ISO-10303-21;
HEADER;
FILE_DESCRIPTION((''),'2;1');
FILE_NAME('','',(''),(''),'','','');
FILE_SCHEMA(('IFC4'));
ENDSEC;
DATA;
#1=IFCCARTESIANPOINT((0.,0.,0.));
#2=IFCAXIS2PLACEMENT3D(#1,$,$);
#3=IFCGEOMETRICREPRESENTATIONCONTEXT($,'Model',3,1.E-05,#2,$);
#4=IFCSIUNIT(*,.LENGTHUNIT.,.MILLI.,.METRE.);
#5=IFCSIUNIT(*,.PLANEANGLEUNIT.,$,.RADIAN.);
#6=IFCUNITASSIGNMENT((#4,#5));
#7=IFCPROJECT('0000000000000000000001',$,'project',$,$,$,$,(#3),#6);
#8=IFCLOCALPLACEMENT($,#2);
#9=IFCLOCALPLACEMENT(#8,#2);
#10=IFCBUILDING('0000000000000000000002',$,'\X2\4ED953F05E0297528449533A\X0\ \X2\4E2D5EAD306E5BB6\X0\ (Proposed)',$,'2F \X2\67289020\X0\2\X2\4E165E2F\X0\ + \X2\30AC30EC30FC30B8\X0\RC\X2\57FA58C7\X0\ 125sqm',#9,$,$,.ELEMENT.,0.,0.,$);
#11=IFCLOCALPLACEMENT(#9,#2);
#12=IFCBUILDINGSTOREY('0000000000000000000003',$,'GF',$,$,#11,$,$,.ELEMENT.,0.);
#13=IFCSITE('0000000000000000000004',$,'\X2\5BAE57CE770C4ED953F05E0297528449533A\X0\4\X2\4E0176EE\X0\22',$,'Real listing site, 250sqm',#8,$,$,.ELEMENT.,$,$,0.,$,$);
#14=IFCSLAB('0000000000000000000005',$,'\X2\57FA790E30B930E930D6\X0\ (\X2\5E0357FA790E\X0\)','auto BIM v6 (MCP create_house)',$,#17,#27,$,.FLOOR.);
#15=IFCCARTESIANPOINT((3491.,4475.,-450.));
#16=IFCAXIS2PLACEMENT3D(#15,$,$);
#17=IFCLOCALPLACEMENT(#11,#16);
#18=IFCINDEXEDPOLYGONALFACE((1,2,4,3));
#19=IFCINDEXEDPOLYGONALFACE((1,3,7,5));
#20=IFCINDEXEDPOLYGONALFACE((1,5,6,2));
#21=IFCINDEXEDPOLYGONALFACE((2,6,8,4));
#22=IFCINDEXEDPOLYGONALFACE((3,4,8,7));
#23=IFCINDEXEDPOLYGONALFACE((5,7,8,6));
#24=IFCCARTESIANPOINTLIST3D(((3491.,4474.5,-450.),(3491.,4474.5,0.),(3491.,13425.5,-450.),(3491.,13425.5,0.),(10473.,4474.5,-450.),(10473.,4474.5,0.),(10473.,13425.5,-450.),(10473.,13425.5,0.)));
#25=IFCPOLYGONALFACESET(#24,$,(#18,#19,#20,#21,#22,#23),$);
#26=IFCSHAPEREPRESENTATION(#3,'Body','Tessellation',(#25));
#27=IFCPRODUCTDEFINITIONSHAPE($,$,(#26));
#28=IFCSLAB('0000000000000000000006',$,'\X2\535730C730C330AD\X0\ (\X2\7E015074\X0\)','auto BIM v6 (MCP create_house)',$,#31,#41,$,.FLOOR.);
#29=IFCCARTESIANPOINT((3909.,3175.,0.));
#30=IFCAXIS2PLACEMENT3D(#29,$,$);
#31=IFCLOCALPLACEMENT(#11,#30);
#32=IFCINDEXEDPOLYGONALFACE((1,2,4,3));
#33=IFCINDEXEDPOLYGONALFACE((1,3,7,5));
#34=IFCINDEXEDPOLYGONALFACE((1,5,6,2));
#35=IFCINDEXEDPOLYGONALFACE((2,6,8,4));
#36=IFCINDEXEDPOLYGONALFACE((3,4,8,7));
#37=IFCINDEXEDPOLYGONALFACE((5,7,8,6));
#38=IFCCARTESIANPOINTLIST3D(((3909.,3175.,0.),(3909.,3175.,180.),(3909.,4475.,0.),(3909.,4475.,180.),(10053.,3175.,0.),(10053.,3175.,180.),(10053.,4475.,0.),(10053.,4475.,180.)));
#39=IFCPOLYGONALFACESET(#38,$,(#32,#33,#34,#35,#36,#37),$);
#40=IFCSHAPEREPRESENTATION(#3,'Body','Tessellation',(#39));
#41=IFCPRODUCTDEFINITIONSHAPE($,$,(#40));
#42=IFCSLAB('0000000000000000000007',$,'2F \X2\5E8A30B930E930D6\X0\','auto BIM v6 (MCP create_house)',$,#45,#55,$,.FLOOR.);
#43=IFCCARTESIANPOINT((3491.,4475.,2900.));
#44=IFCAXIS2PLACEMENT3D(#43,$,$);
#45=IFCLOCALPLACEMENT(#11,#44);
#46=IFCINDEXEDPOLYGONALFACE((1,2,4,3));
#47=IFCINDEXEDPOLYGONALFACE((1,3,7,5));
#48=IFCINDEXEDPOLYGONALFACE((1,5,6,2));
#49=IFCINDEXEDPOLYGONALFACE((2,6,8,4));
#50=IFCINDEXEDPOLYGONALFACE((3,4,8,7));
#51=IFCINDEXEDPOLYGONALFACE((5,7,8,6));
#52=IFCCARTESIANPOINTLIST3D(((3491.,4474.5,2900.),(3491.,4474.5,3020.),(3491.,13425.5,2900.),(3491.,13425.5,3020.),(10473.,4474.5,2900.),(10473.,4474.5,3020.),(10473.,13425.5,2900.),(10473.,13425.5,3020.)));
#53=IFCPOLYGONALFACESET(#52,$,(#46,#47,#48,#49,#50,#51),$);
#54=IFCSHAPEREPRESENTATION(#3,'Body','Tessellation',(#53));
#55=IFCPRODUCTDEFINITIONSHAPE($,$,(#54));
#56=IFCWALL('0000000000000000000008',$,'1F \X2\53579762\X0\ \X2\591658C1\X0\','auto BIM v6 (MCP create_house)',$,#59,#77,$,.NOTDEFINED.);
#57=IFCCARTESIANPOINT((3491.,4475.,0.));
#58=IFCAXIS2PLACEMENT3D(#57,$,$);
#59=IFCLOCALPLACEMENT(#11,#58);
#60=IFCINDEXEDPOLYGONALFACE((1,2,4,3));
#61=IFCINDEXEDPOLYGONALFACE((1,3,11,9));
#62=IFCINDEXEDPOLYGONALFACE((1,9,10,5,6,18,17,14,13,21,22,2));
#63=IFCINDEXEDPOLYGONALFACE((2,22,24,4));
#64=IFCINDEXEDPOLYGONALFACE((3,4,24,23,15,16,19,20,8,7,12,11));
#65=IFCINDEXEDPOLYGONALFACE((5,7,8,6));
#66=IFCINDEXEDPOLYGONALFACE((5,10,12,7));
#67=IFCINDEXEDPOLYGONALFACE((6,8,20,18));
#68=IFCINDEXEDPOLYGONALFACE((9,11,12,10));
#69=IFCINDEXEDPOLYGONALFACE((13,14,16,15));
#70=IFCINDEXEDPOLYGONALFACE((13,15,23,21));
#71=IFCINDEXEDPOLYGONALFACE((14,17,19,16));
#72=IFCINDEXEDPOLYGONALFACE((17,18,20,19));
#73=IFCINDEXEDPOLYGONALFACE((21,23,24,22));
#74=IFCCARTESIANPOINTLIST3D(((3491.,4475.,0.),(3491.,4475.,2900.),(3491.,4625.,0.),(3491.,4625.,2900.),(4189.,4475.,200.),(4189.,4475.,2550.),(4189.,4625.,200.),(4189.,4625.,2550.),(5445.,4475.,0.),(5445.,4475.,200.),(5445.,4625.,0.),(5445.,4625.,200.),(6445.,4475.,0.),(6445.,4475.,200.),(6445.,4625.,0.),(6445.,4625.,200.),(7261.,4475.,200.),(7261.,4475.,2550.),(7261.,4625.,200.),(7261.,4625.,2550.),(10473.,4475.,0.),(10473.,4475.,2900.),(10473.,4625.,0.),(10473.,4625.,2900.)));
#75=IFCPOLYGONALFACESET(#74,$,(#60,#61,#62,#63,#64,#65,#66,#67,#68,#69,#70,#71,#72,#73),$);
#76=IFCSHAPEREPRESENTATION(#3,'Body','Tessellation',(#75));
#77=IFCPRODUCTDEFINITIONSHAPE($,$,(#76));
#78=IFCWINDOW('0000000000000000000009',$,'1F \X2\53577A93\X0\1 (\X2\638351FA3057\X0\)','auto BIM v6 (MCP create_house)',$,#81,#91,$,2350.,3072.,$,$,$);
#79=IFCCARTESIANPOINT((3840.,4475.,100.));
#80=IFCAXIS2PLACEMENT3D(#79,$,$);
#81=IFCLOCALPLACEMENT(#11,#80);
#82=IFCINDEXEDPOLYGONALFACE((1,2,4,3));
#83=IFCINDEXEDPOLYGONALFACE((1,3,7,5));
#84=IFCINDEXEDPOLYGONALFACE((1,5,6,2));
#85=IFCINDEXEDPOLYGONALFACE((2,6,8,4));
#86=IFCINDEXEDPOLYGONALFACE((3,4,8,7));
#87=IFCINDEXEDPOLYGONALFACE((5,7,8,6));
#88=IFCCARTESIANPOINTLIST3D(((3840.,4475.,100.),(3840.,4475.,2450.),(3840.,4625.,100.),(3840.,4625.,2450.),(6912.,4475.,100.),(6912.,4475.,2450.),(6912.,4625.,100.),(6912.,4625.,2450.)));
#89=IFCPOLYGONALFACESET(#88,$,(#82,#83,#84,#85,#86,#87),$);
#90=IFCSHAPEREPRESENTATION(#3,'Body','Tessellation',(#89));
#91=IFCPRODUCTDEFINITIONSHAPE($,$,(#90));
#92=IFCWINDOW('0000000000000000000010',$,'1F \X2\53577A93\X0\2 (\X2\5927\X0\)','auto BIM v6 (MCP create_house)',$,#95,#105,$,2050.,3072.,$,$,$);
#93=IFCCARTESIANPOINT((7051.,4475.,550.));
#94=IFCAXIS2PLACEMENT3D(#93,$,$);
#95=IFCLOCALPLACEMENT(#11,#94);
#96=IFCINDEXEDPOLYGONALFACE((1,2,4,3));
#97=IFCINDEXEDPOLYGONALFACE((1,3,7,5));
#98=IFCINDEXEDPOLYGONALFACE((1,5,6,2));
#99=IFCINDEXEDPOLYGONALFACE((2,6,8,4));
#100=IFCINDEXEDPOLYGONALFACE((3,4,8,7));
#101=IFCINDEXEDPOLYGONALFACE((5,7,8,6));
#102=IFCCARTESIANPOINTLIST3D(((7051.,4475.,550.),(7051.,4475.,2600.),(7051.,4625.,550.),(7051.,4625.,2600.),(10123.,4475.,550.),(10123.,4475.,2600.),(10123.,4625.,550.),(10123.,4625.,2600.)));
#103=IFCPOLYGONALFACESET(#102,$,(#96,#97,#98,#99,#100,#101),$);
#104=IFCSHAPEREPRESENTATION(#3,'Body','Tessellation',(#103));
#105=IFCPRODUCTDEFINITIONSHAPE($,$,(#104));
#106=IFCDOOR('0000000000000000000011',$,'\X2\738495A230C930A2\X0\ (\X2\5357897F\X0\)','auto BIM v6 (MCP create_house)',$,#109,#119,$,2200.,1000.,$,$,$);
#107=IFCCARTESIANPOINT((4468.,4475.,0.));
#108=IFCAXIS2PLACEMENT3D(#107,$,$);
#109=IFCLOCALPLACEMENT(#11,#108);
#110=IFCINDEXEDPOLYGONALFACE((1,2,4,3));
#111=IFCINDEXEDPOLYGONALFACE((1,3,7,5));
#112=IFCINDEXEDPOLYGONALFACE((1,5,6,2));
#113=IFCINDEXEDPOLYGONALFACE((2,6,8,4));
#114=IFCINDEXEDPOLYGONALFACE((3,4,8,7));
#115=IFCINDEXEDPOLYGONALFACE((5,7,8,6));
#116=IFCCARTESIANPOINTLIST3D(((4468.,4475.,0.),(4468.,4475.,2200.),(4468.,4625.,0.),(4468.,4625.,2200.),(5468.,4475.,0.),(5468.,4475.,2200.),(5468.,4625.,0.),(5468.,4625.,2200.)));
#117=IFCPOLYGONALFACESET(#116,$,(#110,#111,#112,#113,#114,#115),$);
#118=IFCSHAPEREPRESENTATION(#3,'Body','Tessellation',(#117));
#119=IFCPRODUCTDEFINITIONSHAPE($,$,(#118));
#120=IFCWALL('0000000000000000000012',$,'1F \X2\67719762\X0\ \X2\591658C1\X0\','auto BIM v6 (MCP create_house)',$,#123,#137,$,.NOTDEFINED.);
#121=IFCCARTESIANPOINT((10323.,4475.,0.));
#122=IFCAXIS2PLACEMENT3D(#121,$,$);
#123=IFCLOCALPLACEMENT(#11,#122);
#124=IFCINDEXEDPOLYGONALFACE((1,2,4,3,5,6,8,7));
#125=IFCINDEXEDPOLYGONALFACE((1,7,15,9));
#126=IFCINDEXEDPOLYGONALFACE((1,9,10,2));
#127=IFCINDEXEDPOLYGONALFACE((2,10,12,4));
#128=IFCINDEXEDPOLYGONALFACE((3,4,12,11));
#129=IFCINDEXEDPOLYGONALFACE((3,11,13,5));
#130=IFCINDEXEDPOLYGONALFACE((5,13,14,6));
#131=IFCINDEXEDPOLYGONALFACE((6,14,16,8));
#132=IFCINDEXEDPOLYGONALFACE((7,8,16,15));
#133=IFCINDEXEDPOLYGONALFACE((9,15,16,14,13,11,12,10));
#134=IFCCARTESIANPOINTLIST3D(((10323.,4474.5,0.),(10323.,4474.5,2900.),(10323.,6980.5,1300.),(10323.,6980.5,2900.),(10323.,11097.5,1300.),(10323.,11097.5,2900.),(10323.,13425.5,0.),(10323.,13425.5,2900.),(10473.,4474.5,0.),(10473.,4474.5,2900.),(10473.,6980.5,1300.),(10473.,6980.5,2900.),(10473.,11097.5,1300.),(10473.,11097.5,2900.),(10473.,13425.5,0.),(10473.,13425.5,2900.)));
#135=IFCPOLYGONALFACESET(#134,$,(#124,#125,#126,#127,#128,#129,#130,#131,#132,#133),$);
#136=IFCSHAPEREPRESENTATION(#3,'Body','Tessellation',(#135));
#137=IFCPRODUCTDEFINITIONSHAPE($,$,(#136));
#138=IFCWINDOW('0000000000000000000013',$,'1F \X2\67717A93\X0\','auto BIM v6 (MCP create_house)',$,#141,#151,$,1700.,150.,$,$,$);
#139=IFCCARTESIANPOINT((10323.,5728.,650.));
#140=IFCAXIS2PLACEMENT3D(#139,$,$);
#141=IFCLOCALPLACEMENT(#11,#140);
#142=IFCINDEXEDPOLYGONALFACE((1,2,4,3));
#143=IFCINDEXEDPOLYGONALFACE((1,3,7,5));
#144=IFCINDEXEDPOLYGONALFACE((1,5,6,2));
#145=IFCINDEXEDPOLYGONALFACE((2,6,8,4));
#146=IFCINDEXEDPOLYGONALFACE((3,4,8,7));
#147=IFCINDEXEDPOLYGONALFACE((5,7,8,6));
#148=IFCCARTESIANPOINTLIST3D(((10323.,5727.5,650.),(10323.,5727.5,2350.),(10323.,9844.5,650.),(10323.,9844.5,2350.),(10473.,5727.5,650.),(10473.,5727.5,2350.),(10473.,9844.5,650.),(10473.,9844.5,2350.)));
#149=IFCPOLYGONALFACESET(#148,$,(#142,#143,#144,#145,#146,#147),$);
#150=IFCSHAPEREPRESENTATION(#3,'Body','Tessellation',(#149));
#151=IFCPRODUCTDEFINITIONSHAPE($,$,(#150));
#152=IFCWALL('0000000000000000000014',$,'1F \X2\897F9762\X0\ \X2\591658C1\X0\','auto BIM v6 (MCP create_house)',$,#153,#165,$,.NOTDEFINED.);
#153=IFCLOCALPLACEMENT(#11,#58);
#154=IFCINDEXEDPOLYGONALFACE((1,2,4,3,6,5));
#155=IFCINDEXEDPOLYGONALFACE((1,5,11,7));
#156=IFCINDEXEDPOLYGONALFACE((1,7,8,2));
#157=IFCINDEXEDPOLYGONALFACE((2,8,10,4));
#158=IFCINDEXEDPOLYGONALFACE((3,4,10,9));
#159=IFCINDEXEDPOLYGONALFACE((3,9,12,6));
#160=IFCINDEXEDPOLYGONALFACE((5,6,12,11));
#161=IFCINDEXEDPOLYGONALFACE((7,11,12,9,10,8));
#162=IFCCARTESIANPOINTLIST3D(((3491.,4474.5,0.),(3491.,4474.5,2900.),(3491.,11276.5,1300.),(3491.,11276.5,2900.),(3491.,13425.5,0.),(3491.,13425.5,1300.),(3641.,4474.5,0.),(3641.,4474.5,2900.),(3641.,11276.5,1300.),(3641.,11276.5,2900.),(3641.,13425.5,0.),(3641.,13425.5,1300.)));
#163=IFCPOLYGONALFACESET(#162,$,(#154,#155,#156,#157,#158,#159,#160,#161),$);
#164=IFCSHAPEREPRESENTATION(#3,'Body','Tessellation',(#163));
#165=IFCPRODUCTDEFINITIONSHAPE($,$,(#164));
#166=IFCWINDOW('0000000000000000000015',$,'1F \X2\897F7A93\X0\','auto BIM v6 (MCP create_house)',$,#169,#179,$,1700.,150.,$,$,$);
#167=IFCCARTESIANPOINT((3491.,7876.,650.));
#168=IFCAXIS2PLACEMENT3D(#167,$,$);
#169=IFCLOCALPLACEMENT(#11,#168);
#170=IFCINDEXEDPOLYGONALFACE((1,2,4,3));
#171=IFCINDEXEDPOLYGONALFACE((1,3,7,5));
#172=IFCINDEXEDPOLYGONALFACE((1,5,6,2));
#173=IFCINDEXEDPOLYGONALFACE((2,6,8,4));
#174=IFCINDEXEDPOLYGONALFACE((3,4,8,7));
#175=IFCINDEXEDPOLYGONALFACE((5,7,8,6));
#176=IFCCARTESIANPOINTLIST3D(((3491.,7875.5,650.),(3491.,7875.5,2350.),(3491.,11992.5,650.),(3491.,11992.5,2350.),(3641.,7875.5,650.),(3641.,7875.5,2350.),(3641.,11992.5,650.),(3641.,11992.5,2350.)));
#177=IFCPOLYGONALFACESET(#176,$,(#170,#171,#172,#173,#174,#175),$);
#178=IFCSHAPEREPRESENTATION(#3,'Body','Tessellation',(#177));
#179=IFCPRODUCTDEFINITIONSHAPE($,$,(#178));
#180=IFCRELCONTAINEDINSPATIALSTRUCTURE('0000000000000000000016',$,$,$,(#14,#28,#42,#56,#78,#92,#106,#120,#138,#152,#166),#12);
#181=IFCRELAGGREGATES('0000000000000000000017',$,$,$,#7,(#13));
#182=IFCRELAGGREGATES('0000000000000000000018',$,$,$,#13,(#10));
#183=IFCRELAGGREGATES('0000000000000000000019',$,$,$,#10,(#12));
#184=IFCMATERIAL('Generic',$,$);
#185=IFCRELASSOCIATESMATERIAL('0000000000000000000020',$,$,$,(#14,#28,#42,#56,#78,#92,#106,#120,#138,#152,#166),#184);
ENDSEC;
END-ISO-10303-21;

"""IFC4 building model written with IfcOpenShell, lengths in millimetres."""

from ifc_helpers import new_model, si_unit, frame, frame_2d, origin, place, context, project, spatial, rectangle, extrude, material, element, fill, save


model = new_model("IFC4")

# Units and contexts
model_context = context("Model", 3, precision=1e-05, world=origin())
ifc_project = project(units=[si_unit("LENGTHUNIT", "METRE", prefix="MILLI"), si_unit("PLANEANGLEUNIT", "RADIAN")], contexts=[model_context])

# Site, building, storey
site_placement = place(None, origin())
site = spatial("IfcSite", under=ifc_project, at=site_placement, Name="宮城県仙台市青葉区4丁目22", ObjectType="Real listing site, 250sqm", CompositionType="ELEMENT", RefElevation=0.0)
building_placement = place(site_placement, origin())
building = spatial("IfcBuilding", under=site, at=building_placement, Name="仙台市青葉区 中庭の家 (Proposed)", ObjectType="2F 木造2世帯 + ガレージRC基壇 125sqm", CompositionType="ELEMENT", ElevationOfRefHeight=0.0, ElevationOfTerrain=0.0)
storey_placement = place(building_placement, origin())
storey = spatial("IfcBuildingStorey", under=building, at=storey_placement, Name="GF", CompositionType="ELEMENT", Elevation=0.0)

# Slabs
ifc_material = material(Name="Generic")
slab_1_placement = place(storey_placement, frame((3491.0, 4475.0, -450.0)))
element("IfcSlab", 1, at=slab_1_placement, inside=storey, material=ifc_material, Name="基礎スラブ (布基礎)", Description="auto BIM v6 (MCP create_house)", PredefinedType="FLOOR", context=model_context, shape_type="SweptSolid", body=[
    extrude(rectangle(XDim=6982.0, YDim=8951.0, at=frame_2d((3491.0, 4475.0))), frame((3491.0, 4475.0, -450.0)), (0.0, 0.0, 1.0), 450.0),
])
slab_2_placement = place(storey_placement, frame((3909.0, 3175.0, 0.0)))
element("IfcSlab", 2, at=slab_2_placement, inside=storey, material=ifc_material, Name="南デッキ (縁側)", Description="auto BIM v6 (MCP create_house)", PredefinedType="FLOOR", context=model_context, shape_type="SweptSolid", body=[
    extrude(rectangle(XDim=6144.0, YDim=1300.0, at=frame_2d((3072.0, 650.0))), frame((3909.0, 3175.0, 0.0)), (0.0, 0.0, 1.0), 180.0),
])
slab_3_placement = place(storey_placement, frame((3491.0, 4475.0, 2900.0)))
element("IfcSlab", 3, at=slab_3_placement, inside=storey, material=ifc_material, Name="2F 床スラブ", Description="auto BIM v6 (MCP create_house)", PredefinedType="FLOOR", context=model_context, shape_type="SweptSolid", body=[
    extrude(rectangle(XDim=6982.0, YDim=8951.0, at=frame_2d((3491.0, 4475.0))), frame((3491.0, 4475.0, 2900.0)), (0.0, 0.0, 1.0), 120.0),
])

# Wall, openings, windows, door
wall_1_placement = place(storey_placement, frame((3491.0, 4475.0, 0.0)))
wall_1 = element("IfcWall", 4, at=wall_1_placement, inside=storey, material=ifc_material, Name="1F 南面 外壁", Description="auto BIM v6 (MCP create_house)", PredefinedType="NOTDEFINED", context=model_context, shape_type="SweptSolid", body=[
    extrude(rectangle(XDim=6982.0, YDim=150.0, at=frame_2d((3491.0, 75.0))), frame((3491.0, 4475.0, 0.0)), (0.0, 0.0, 1.0), 2900.0),
])
opening_1_placement = place(storey_placement, frame((3840.0, 4475.0, 100.0)))
opening_1 = element("IfcOpeningElement", 5, at=opening_1_placement, cuts=wall_1, PredefinedType="NOTDEFINED", context=model_context, shape_type="SweptSolid", body=[
    extrude(rectangle(XDim=3072.0, YDim=150.0, at=frame_2d((1536.0, 75.0))), frame((3840.0, 4475.0, 100.0)), (0.0, 0.0, 1.0), 2350.0),
])
opening_2_placement = place(storey_placement, frame((7051.0, 4475.0, 550.0)))
opening_2 = element("IfcOpeningElement", 6, at=opening_2_placement, cuts=wall_1, PredefinedType="NOTDEFINED", context=model_context, shape_type="SweptSolid", body=[
    extrude(rectangle(XDim=3072.0, YDim=150.0, at=frame_2d((1536.0, 75.0))), frame((7051.0, 4475.0, 550.0)), (0.0, 0.0, 1.0), 2050.0),
])
opening_3_placement = place(storey_placement, frame((4468.0, 4475.0, 0.0)))
opening_3 = element("IfcOpeningElement", 7, at=opening_3_placement, cuts=wall_1, PredefinedType="NOTDEFINED", context=model_context, shape_type="SweptSolid", body=[
    extrude(rectangle(XDim=1000.0, YDim=150.0, at=frame_2d((500.0, 75.0))), frame((4468.0, 4475.0, 0.0)), (0.0, 0.0, 1.0), 2200.0),
])
window_1_placement = place(storey_placement, frame((3840.0, 4475.0, 100.0)))
window_1 = element("IfcWindow", 8, at=window_1_placement, inside=storey, material=ifc_material, Name="1F 南窓1 (掃出し)", Description="auto BIM v6 (MCP create_house)", OverallHeight=2350.0, OverallWidth=3072.0, context=model_context, shape_type="SweptSolid", body=[
    extrude(rectangle(XDim=3072.0, YDim=150.0, at=frame_2d((1536.0, 75.0))), frame((3840.0, 4475.0, 100.0)), (0.0, 0.0, 1.0), 2350.0),
])
fill(opening_1, window_1)
window_2_placement = place(storey_placement, frame((7051.0, 4475.0, 550.0)))
window_2 = element("IfcWindow", 9, at=window_2_placement, inside=storey, material=ifc_material, Name="1F 南窓2 (大)", Description="auto BIM v6 (MCP create_house)", OverallHeight=2050.0, OverallWidth=3072.0, context=model_context, shape_type="SweptSolid", body=[
    extrude(rectangle(XDim=3072.0, YDim=150.0, at=frame_2d((1536.0, 75.0))), frame((7051.0, 4475.0, 550.0)), (0.0, 0.0, 1.0), 2050.0),
])
fill(opening_2, window_2)
door_placement = place(storey_placement, frame((4468.0, 4475.0, 0.0)))
door = element("IfcDoor", 10, at=door_placement, inside=storey, material=ifc_material, Name="玄関ドア (南西)", Description="auto BIM v6 (MCP create_house)", OverallHeight=2200.0, OverallWidth=1000.0, context=model_context, shape_type="SweptSolid", body=[
    extrude(rectangle(XDim=1000.0, YDim=150.0, at=frame_2d((500.0, 75.0))), frame((4468.0, 4475.0, 0.0)), (0.0, 0.0, 1.0), 2200.0),
])
fill(opening_3, door)

# Walls, openings, windows
wall_2_placement = place(storey_placement, frame((10323.0, 4475.0, 0.0)))
wall_2 = element("IfcWall", 11, at=wall_2_placement, inside=storey, material=ifc_material, Name="1F 東面 外壁", Description="auto BIM v6 (MCP create_house)", PredefinedType="NOTDEFINED", context=model_context, shape_type="SweptSolid", body=[
    extrude(rectangle(XDim=150.0, YDim=8951.0, at=frame_2d((75.0, 4475.0))), frame((10323.0, 4475.0, 0.0)), (0.0, 0.0, 1.0), 2900.0),
])
opening_4_placement = place(storey_placement, frame((10323.0, 5728.0, 650.0)))
opening_4 = element("IfcOpeningElement", 12, at=opening_4_placement, cuts=wall_2, PredefinedType="NOTDEFINED", context=model_context, shape_type="SweptSolid", body=[
    extrude(rectangle(XDim=150.0, YDim=4117.0, at=frame_2d((75.0, 2058.0))), frame((10323.0, 5728.0, 650.0)), (0.0, 0.0, 1.0), 1700.0),
])
window_3_placement = place(storey_placement, frame((10323.0, 5728.0, 650.0)))
window_3 = element("IfcWindow", 13, at=window_3_placement, inside=storey, material=ifc_material, Name="1F 東窓", Description="auto BIM v6 (MCP create_house)", OverallHeight=1700.0, OverallWidth=150.0, context=model_context, shape_type="SweptSolid", body=[
    extrude(rectangle(XDim=150.0, YDim=4117.0, at=frame_2d((75.0, 2058.0))), frame((10323.0, 5728.0, 650.0)), (0.0, 0.0, 1.0), 1700.0),
])
fill(opening_4, window_3)
wall_3_placement = place(storey_placement, frame((3491.0, 4475.0, 0.0)))
wall_3 = element("IfcWall", 14, at=wall_3_placement, inside=storey, material=ifc_material, Name="1F 西面 外壁", Description="auto BIM v6 (MCP create_house)", PredefinedType="NOTDEFINED", context=model_context, shape_type="SweptSolid", body=[
    extrude(rectangle(XDim=150.0, YDim=8951.0, at=frame_2d((75.0, 4475.0))), frame((3491.0, 4475.0, 0.0)), (0.0, 0.0, 1.0), 2900.0),
])
opening_5_placement = place(storey_placement, frame((3491.0, 7876.0, 650.0)))
opening_5 = element("IfcOpeningElement", 15, at=opening_5_placement, cuts=wall_3, PredefinedType="NOTDEFINED", context=model_context, shape_type="SweptSolid", body=[
    extrude(rectangle(XDim=150.0, YDim=4117.0, at=frame_2d((75.0, 2058.0))), frame((3491.0, 7876.0, 650.0)), (0.0, 0.0, 1.0), 1700.0),
])
window_4_placement = place(storey_placement, frame((3491.0, 7876.0, 650.0)))
window_4 = element("IfcWindow", 16, at=window_4_placement, inside=storey, material=ifc_material, Name="1F 西窓", Description="auto BIM v6 (MCP create_house)", OverallHeight=1700.0, OverallWidth=150.0, context=model_context, shape_type="SweptSolid", body=[
    extrude(rectangle(XDim=150.0, YDim=4117.0, at=frame_2d((75.0, 2058.0))), frame((3491.0, 7876.0, 650.0)), (0.0, 0.0, 1.0), 1700.0),
])
fill(opening_5, window_4)

save(model, "model.ifc")
